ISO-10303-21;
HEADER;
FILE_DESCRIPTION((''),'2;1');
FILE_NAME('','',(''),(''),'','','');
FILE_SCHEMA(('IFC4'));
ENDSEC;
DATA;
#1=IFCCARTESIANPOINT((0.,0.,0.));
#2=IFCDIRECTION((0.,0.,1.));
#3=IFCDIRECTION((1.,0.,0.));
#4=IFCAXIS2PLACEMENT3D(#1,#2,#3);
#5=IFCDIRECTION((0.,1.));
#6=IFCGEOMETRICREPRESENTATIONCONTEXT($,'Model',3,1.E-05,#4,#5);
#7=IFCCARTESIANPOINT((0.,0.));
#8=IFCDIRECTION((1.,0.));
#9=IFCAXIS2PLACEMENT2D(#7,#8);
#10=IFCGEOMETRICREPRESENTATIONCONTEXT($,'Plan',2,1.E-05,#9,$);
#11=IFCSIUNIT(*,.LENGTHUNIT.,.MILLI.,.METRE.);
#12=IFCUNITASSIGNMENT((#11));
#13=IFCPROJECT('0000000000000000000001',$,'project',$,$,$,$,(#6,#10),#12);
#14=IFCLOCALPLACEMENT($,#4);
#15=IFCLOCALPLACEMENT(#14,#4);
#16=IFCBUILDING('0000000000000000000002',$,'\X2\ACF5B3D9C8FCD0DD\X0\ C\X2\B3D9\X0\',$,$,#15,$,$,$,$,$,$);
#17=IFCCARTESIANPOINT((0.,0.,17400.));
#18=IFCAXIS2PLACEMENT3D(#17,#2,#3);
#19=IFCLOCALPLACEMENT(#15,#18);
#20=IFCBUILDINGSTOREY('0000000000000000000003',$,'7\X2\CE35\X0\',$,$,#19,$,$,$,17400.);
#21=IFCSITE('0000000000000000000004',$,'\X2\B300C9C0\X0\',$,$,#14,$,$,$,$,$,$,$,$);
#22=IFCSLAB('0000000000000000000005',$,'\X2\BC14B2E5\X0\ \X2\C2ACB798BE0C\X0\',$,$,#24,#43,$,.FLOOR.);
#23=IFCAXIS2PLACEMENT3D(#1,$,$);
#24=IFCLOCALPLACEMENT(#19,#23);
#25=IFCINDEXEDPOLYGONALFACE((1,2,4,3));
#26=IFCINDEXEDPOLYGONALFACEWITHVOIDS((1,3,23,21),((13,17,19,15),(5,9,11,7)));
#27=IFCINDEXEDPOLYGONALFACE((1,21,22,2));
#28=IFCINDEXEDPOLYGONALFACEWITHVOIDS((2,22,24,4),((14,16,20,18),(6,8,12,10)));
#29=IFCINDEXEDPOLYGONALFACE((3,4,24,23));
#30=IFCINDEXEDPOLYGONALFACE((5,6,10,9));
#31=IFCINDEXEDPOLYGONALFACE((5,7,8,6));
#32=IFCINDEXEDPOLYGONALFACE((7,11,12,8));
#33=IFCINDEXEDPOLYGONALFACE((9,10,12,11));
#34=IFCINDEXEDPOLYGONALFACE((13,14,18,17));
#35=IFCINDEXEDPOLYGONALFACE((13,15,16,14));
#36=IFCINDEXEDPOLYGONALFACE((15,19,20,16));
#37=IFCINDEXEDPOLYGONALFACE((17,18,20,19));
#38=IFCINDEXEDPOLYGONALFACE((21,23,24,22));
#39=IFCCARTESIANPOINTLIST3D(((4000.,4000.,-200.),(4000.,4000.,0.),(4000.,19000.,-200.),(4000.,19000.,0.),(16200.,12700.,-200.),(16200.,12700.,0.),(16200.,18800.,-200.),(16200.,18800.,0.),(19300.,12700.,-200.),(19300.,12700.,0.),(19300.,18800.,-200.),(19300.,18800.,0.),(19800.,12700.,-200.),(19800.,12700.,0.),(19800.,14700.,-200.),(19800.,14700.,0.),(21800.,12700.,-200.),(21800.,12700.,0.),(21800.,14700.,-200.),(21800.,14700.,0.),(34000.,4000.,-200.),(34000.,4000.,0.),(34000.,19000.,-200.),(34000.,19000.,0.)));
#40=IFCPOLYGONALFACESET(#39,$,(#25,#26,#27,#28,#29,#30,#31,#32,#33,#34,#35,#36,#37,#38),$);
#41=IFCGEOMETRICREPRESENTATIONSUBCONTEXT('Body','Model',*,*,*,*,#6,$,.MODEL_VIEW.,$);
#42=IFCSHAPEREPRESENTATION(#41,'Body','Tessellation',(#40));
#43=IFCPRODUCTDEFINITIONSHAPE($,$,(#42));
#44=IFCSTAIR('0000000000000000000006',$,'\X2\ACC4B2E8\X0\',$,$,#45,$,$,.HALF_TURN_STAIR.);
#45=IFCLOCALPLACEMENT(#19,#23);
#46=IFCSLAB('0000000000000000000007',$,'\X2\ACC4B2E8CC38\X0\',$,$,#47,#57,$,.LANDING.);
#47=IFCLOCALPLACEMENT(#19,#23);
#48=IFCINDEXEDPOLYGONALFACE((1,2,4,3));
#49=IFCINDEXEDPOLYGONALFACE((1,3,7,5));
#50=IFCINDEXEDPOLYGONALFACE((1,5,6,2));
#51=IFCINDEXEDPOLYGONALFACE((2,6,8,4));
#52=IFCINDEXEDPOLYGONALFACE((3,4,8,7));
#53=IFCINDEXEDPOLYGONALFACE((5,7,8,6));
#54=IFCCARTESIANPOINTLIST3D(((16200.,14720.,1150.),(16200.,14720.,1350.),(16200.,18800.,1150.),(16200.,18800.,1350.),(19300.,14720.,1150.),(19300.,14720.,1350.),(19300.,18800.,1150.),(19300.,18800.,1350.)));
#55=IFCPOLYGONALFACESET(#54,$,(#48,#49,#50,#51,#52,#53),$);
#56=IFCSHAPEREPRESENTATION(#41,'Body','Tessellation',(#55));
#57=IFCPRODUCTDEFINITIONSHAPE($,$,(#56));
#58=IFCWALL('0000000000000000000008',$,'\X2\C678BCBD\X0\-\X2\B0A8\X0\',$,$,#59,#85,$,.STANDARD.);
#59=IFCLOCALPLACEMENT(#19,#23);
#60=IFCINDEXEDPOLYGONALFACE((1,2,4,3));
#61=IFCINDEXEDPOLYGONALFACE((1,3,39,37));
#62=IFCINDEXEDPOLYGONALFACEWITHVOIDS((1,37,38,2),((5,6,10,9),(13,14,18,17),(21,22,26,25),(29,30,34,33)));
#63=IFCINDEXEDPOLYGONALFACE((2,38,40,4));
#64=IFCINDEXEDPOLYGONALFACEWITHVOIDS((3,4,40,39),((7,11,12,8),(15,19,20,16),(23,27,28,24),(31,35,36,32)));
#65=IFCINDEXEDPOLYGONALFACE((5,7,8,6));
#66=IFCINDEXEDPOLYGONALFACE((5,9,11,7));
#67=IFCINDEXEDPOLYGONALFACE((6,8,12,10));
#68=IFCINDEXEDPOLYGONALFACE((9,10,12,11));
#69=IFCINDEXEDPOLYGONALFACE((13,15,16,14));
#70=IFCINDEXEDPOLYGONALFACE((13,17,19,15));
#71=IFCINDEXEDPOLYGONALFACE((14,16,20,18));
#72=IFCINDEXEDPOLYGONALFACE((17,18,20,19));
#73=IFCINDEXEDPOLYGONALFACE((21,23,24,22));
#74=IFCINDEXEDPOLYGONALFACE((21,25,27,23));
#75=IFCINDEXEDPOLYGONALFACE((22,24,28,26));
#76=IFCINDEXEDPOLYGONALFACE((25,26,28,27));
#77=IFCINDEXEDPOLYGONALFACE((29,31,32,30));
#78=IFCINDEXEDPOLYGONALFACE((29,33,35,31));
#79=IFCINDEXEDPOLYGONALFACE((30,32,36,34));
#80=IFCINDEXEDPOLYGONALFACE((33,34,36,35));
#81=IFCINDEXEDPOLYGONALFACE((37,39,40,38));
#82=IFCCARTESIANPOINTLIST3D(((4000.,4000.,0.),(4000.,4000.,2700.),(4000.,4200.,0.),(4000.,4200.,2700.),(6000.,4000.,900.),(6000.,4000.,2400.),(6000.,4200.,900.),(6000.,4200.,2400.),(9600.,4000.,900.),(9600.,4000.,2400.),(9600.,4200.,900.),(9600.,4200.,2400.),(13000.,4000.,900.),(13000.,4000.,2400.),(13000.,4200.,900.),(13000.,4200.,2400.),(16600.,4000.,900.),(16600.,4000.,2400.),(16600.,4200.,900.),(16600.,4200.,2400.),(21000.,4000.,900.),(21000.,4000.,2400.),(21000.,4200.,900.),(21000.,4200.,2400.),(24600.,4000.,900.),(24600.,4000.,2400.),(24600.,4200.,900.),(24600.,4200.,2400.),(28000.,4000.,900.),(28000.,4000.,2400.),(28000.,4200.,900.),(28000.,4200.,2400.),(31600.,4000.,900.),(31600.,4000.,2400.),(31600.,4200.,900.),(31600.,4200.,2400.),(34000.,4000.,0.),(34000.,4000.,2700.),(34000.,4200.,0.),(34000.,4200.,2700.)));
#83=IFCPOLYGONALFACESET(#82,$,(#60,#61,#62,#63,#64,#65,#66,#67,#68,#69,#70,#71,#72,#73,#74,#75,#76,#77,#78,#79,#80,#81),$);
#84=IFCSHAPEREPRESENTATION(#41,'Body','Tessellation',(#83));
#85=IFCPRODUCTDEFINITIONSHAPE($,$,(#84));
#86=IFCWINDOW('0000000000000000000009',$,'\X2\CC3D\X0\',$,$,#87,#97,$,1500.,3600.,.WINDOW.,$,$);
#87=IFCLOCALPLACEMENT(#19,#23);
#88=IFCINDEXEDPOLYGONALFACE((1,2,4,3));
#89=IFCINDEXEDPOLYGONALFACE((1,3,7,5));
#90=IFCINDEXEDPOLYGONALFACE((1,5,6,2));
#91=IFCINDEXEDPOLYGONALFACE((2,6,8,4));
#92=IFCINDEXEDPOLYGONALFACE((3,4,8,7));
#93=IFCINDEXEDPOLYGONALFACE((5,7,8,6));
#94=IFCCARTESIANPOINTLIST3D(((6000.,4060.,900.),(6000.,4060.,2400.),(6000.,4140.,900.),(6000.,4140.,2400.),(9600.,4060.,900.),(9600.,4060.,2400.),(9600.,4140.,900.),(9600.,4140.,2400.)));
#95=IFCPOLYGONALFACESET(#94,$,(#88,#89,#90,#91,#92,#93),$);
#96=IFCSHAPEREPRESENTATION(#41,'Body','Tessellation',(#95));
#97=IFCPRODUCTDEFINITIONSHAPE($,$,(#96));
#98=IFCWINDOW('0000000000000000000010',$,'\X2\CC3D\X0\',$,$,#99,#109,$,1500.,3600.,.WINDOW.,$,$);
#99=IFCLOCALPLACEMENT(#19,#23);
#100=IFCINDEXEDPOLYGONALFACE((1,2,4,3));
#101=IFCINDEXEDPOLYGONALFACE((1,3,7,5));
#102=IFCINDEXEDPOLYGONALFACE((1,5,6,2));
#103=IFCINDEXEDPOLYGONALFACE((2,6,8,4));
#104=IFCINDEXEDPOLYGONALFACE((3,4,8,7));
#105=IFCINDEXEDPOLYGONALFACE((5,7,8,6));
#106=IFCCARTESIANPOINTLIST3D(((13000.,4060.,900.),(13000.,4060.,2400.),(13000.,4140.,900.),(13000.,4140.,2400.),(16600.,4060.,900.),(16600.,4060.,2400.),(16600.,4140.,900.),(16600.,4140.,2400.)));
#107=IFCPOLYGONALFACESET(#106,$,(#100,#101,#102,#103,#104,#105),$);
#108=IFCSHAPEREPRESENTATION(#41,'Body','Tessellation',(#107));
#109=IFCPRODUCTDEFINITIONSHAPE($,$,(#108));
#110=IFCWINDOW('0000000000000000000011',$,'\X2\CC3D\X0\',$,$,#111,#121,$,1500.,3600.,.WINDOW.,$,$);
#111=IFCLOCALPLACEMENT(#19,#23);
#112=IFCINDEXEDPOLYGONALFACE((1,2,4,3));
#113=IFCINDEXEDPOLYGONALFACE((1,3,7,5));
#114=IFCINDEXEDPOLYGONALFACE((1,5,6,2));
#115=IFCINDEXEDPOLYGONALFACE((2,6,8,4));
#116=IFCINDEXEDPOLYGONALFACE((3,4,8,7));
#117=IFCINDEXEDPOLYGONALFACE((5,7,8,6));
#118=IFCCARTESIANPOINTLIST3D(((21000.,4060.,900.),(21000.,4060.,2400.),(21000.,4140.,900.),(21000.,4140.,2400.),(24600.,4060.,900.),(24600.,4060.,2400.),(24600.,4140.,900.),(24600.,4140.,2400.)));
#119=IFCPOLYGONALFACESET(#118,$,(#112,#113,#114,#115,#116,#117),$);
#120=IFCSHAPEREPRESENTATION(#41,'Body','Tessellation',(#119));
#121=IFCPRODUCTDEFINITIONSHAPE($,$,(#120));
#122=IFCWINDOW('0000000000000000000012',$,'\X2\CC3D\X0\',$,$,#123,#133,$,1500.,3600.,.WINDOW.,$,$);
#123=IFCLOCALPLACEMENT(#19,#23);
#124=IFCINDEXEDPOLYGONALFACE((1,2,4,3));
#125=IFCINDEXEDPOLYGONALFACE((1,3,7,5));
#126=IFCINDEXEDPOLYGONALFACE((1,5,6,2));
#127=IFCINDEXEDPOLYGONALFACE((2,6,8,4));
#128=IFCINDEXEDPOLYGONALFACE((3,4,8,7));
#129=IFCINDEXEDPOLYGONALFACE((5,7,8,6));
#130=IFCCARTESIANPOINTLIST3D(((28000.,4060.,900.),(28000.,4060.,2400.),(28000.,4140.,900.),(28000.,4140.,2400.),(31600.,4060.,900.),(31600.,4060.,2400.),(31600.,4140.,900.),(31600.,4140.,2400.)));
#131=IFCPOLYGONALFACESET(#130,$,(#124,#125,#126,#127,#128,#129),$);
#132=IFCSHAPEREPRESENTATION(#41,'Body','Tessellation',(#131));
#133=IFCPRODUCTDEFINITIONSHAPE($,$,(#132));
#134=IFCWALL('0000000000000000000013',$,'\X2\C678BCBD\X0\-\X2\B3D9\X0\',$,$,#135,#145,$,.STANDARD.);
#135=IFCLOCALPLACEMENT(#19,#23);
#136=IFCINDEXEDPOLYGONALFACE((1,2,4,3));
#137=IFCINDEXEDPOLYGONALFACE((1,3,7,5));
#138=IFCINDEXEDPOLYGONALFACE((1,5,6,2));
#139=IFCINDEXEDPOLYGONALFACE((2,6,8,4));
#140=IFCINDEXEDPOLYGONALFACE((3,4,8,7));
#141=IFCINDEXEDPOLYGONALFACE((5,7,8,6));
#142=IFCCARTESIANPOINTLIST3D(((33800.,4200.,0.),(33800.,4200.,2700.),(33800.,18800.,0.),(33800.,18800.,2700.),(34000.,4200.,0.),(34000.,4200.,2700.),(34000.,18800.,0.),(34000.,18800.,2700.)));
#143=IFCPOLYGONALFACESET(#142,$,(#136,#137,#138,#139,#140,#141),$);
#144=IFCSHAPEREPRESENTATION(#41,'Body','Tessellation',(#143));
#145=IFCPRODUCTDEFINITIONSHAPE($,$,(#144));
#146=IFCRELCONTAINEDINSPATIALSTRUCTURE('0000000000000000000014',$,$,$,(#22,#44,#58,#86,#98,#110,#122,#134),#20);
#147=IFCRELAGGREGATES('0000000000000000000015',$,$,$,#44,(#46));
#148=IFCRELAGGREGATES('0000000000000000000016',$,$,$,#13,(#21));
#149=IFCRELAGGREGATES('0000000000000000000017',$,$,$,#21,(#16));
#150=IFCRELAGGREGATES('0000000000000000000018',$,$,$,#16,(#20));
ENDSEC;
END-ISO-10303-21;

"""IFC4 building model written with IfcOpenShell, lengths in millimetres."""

from ifc_helpers import new_model, si_unit, direction, frame, origin_with_axes, origin_2d_with_axis, place, context, subcontext, project, spatial, polyline, outline, extrude, element, fill, aggregate, save


model = new_model("IFC4")

# Units and contexts
model_context = context("Model", 3, precision=1e-05, world=origin_with_axes(), true_north=direction((0.0, 1.0)))
plan_context = context("Plan", 2, precision=1e-05, world=origin_2d_with_axis())
body_context = subcontext(model_context, "Body", "Model", "MODEL_VIEW")
ifc_project = project(units=[si_unit("LENGTHUNIT", "METRE", prefix="MILLI")], contexts=[model_context, plan_context])

# Site, building, storey
site_placement = place(None, origin_with_axes())
site = spatial("IfcSite", under=ifc_project, at=site_placement, Name="대지")
building_placement = place(site_placement, origin_with_axes())
building = spatial("IfcBuilding", under=site, at=building_placement, Name="공동주택 C동")
storey_placement = place(building_placement, frame((0.0, 0.0, 17400.0), z_axis=(0.0, 0.0, 1.0), x_axis=(1.0, 0.0, 0.0)))
storey = spatial("IfcBuildingStorey", under=building, at=storey_placement, Name="7층", Elevation=17400.0)

# Slab
slab_1_placement = place(storey_placement, origin_with_axes())
element("IfcSlab", 1, at=slab_1_placement, inside=storey, Name="바닥 슬래브", PredefinedType="FLOOR", context=body_context, shape_type="SweptSolid", body=[
    extrude(outline(polyline([(4000.0, 4000.0), (34000.0, 4000.0), (34000.0, 19000.0), (4000.0, 19000.0), (4000.0, 4000.0)]), holes=[polyline([(16200.0, 12700.0), (19300.0, 12700.0), (19300.0, 18800.0), (16200.0, 18800.0), (16200.0, 12700.0)]), polyline([(19800.0, 12700.0), (21800.0, 12700.0), (21800.0, 14700.0), (19800.0, 14700.0), (19800.0, 12700.0)])]), frame((0.0, 0.0, -200.0), z_axis=(0.0, 0.0, 1.0), x_axis=(1.0, 0.0, 0.0)), (0.0, 0.0, 1.0), 200.0),
])

# Stair, slab
stair_placement = place(storey_placement, origin_with_axes())
stair = element("IfcStair", 2, at=stair_placement, inside=storey, Name="계단", PredefinedType="HALF_TURN_STAIR")
slab_2_placement = place(stair_placement, origin_with_axes())
slab_2 = element("IfcSlab", 3, at=slab_2_placement, Name="계단참", PredefinedType="LANDING", context=body_context, shape_type="SweptSolid", body=[
    extrude(outline(polyline([(16200.0, 14720.0), (19300.0, 14720.0), (19300.0, 18800.0), (16200.0, 18800.0), (16200.0, 14720.0)])), frame((0.0, 0.0, 1150.0), z_axis=(0.0, 0.0, 1.0), x_axis=(1.0, 0.0, 0.0)), (0.0, 0.0, 1.0), 200.0),
])

# Wall, openings, windows
wall_1_placement = place(storey_placement, origin_with_axes())
wall_1 = element("IfcWall", 4, at=wall_1_placement, inside=storey, Name="외벽-남", PredefinedType="STANDARD", context=body_context, shape_type="SweptSolid", body=[
    extrude(outline(polyline([(4000.0, 4200.0), (34000.0, 4200.0), (34000.0, 4000.0), (4000.0, 4000.0), (4000.0, 4200.0)])), origin_with_axes(), (0.0, 0.0, 1.0), 2700.0),
])
opening_1_placement = place(storey_placement, origin_with_axes())
opening_1 = element("IfcOpeningElement", 5, at=opening_1_placement, cuts=wall_1, PredefinedType="OPENING", context=body_context, shape_type="SweptSolid", body=[
    extrude(outline(polyline([(6000.0, 3950.0), (9600.0, 3950.0), (9600.0, 4250.0), (6000.0, 4250.0), (6000.0, 3950.0)])), frame((0.0, 0.0, 900.0), z_axis=(0.0, 0.0, 1.0), x_axis=(1.0, 0.0, 0.0)), (0.0, 0.0, 1.0), 1500.0),
])
opening_2_placement = place(storey_placement, origin_with_axes())
opening_2 = element("IfcOpeningElement", 6, at=opening_2_placement, cuts=wall_1, PredefinedType="OPENING", context=body_context, shape_type="SweptSolid", body=[
    extrude(outline(polyline([(13000.0, 3950.0), (16600.0, 3950.0), (16600.0, 4250.0), (13000.0, 4250.0), (13000.0, 3950.0)])), frame((0.0, 0.0, 900.0), z_axis=(0.0, 0.0, 1.0), x_axis=(1.0, 0.0, 0.0)), (0.0, 0.0, 1.0), 1500.0),
])
opening_3_placement = place(storey_placement, origin_with_axes())
opening_3 = element("IfcOpeningElement", 7, at=opening_3_placement, cuts=wall_1, PredefinedType="OPENING", context=body_context, shape_type="SweptSolid", body=[
    extrude(outline(polyline([(21000.0, 3950.0), (24600.0, 3950.0), (24600.0, 4250.0), (21000.0, 4250.0), (21000.0, 3950.0)])), frame((0.0, 0.0, 900.0), z_axis=(0.0, 0.0, 1.0), x_axis=(1.0, 0.0, 0.0)), (0.0, 0.0, 1.0), 1500.0),
])
opening_4_placement = place(storey_placement, origin_with_axes())
opening_4 = element("IfcOpeningElement", 8, at=opening_4_placement, cuts=wall_1, PredefinedType="OPENING", context=body_context, shape_type="SweptSolid", body=[
    extrude(outline(polyline([(28000.0, 3950.0), (31600.0, 3950.0), (31600.0, 4250.0), (28000.0, 4250.0), (28000.0, 3950.0)])), frame((0.0, 0.0, 900.0), z_axis=(0.0, 0.0, 1.0), x_axis=(1.0, 0.0, 0.0)), (0.0, 0.0, 1.0), 1500.0),
])
window_1_placement = place(storey_placement, origin_with_axes())
window_1 = element("IfcWindow", 9, at=window_1_placement, inside=storey, Name="창", OverallHeight=1500.0, OverallWidth=3600.0, PredefinedType="WINDOW", context=body_context, shape_type="SweptSolid", body=[
    extrude(outline(polyline([(6000.0, 4060.0), (9600.0, 4060.0), (9600.0, 4140.0), (6000.0, 4140.0), (6000.0, 4060.0)])), frame((0.0, 0.0, 900.0), z_axis=(0.0, 0.0, 1.0), x_axis=(1.0, 0.0, 0.0)), (0.0, 0.0, 1.0), 1500.0),
])
fill(opening_1, window_1)
window_2_placement = place(storey_placement, origin_with_axes())
window_2 = element("IfcWindow", 10, at=window_2_placement, inside=storey, Name="창", OverallHeight=1500.0, OverallWidth=3600.0, PredefinedType="WINDOW", context=body_context, shape_type="SweptSolid", body=[
    extrude(outline(polyline([(13000.0, 4060.0), (16600.0, 4060.0), (16600.0, 4140.0), (13000.0, 4140.0), (13000.0, 4060.0)])), frame((0.0, 0.0, 900.0), z_axis=(0.0, 0.0, 1.0), x_axis=(1.0, 0.0, 0.0)), (0.0, 0.0, 1.0), 1500.0),
])
fill(opening_2, window_2)
window_3_placement = place(storey_placement, origin_with_axes())
window_3 = element("IfcWindow", 11, at=window_3_placement, inside=storey, Name="창", OverallHeight=1500.0, OverallWidth=3600.0, PredefinedType="WINDOW", context=body_context, shape_type="SweptSolid", body=[
    extrude(outline(polyline([(21000.0, 4060.0), (24600.0, 4060.0), (24600.0, 4140.0), (21000.0, 4140.0), (21000.0, 4060.0)])), frame((0.0, 0.0, 900.0), z_axis=(0.0, 0.0, 1.0), x_axis=(1.0, 0.0, 0.0)), (0.0, 0.0, 1.0), 1500.0),
])
fill(opening_3, window_3)
window_4_placement = place(storey_placement, origin_with_axes())
window_4 = element("IfcWindow", 12, at=window_4_placement, inside=storey, Name="창", OverallHeight=1500.0, OverallWidth=3600.0, PredefinedType="WINDOW", context=body_context, shape_type="SweptSolid", body=[
    extrude(outline(polyline([(28000.0, 4060.0), (31600.0, 4060.0), (31600.0, 4140.0), (28000.0, 4140.0), (28000.0, 4060.0)])), frame((0.0, 0.0, 900.0), z_axis=(0.0, 0.0, 1.0), x_axis=(1.0, 0.0, 0.0)), (0.0, 0.0, 1.0), 1500.0),
])
fill(opening_4, window_4)

# Wall
wall_2_placement = place(storey_placement, origin_with_axes())
element("IfcWall", 13, at=wall_2_placement, inside=storey, Name="외벽-동", PredefinedType="STANDARD", context=body_context, shape_type="SweptSolid", body=[
    extrude(outline(polyline([(33800.0, 4200.0), (33800.0, 18800.0), (34000.0, 18800.0), (34000.0, 4200.0), (33800.0, 4200.0)])), origin_with_axes(), (0.0, 0.0, 1.0), 2700.0),
])

aggregate(stair, [slab_2])

save(model, "model.ifc")
